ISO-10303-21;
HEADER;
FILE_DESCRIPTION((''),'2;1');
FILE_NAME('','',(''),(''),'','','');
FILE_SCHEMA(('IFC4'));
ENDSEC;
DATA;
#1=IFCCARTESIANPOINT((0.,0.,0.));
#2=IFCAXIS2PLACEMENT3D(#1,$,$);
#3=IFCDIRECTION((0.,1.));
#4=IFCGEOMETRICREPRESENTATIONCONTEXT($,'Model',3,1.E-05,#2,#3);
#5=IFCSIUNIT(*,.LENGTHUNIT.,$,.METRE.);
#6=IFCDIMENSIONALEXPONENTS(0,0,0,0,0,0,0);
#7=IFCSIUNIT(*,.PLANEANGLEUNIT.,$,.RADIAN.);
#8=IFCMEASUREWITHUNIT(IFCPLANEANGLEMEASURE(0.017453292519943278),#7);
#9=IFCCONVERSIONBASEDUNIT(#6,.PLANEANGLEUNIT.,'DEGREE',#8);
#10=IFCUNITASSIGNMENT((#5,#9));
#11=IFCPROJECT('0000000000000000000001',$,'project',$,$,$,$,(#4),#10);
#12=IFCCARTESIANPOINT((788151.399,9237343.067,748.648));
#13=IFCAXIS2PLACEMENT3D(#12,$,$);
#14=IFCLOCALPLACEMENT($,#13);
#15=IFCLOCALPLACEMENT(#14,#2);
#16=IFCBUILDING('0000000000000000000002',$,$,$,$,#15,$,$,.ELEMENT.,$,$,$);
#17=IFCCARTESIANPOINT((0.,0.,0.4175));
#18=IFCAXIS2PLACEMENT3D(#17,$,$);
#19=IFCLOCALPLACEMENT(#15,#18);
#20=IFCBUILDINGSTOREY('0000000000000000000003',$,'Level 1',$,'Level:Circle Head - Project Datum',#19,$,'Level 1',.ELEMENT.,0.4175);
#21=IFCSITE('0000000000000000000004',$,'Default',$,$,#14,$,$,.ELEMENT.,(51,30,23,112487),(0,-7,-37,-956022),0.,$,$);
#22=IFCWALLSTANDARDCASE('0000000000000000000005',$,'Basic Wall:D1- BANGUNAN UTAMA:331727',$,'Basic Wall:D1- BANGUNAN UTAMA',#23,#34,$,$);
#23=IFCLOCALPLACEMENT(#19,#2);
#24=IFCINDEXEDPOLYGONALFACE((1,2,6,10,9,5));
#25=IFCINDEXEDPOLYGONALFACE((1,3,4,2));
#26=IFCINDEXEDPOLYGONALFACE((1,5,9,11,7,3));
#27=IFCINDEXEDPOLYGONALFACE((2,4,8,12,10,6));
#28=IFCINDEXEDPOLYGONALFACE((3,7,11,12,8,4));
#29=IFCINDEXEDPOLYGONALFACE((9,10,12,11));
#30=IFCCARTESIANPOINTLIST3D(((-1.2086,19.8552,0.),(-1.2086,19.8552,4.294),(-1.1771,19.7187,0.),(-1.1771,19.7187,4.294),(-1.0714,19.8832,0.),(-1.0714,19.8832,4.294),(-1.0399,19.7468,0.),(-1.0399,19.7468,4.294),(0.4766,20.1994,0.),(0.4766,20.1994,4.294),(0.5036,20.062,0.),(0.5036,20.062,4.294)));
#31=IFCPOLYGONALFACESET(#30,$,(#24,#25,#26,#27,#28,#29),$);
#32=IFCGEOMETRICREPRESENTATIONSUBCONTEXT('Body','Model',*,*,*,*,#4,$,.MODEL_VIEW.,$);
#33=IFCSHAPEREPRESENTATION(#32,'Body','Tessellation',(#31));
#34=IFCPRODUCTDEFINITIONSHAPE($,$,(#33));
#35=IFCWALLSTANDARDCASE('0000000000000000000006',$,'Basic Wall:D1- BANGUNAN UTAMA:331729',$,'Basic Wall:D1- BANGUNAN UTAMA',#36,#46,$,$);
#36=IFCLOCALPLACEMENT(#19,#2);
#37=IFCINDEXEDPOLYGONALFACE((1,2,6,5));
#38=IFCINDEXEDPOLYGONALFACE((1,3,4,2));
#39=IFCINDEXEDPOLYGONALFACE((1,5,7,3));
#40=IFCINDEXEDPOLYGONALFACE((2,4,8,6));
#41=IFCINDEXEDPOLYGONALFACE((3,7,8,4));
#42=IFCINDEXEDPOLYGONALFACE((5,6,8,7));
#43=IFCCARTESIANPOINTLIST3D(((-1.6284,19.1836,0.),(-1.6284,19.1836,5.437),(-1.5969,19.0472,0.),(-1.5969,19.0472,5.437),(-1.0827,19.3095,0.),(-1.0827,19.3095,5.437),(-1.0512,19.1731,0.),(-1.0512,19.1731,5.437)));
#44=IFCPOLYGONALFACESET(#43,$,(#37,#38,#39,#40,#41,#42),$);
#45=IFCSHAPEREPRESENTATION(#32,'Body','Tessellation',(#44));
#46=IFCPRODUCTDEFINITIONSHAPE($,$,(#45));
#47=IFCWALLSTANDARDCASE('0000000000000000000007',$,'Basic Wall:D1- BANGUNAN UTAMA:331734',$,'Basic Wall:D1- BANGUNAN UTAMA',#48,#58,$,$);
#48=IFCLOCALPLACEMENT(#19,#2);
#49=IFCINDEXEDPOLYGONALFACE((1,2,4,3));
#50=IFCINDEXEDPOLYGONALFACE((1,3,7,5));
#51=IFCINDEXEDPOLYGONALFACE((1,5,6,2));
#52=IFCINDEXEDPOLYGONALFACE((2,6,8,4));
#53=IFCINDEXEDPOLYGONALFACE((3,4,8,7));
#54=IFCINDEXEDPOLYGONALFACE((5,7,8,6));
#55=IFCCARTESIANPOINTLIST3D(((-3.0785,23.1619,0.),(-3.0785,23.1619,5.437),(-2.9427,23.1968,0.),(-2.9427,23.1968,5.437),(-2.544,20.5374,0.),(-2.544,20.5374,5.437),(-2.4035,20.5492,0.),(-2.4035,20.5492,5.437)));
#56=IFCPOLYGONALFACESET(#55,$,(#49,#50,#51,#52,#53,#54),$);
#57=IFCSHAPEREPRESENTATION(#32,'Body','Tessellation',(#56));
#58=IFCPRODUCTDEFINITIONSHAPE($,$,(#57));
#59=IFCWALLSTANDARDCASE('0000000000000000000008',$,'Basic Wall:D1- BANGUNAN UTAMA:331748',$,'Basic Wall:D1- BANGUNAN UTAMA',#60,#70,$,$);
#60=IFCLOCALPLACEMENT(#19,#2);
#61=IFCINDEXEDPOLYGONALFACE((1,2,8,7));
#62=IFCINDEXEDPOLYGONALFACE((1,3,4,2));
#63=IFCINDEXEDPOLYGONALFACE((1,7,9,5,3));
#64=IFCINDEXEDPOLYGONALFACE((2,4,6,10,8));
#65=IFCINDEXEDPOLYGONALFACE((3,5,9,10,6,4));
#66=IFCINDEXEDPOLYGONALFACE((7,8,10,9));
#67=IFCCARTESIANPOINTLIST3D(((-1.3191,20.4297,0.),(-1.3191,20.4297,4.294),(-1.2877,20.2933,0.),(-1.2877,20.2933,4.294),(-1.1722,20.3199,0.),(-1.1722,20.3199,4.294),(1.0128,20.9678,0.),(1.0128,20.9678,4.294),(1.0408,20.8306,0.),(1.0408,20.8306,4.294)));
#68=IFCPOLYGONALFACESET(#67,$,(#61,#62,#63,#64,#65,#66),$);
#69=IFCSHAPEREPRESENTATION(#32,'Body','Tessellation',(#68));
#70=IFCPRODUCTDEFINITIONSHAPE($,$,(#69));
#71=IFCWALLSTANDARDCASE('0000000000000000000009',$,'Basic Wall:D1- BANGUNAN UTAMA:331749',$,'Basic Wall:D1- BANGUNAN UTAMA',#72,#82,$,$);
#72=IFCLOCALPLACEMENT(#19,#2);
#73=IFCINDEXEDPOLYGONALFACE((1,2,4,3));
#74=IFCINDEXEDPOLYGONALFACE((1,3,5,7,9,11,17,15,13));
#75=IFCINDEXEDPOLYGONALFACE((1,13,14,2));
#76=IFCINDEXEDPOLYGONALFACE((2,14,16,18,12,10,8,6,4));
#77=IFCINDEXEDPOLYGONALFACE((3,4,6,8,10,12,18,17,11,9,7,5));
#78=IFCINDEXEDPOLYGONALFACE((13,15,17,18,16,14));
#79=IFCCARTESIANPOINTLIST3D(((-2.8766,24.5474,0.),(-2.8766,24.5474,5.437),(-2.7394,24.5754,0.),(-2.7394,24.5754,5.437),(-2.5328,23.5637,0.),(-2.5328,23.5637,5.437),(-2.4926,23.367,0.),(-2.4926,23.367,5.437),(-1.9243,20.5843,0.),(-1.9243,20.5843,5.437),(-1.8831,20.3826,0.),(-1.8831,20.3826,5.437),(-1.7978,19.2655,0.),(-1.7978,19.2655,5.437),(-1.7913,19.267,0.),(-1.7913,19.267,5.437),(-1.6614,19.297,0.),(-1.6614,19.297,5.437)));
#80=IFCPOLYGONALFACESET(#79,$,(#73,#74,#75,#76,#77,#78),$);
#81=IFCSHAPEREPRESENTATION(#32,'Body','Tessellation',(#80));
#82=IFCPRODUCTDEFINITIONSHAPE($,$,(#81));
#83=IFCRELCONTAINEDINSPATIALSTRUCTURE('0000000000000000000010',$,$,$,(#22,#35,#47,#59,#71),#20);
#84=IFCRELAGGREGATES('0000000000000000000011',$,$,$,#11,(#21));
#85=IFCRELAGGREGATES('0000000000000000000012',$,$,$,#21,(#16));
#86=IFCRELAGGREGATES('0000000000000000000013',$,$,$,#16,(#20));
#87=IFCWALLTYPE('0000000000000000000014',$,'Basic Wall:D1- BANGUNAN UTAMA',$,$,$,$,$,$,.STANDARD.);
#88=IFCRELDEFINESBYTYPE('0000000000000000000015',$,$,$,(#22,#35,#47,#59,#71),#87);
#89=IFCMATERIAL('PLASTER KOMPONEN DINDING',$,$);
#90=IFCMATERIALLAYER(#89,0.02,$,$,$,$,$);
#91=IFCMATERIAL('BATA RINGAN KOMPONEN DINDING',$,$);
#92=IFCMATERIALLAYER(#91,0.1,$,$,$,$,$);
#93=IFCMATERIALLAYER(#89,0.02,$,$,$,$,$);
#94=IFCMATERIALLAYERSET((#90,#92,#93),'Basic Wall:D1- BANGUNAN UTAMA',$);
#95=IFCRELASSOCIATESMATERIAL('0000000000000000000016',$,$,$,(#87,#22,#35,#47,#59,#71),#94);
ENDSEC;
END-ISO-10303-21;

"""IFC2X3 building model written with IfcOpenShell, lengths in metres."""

from ifc_helpers import new_model, entity, si_unit, converted_unit, direction, frame, frame_2d, origin, place, context, subcontext, project, spatial, polyline, rectangle, outline, extrude, material, layer, layer_set, layer_usage, type_object, element, save


model = new_model("IFC2X3")

# Units and contexts
model_context = context("Model", 3, precision=1e-05, world=origin(), true_north=direction((0.0, 1.0)))
body_context = subcontext(model_context, "Body", "Model", "MODEL_VIEW")
ifc_project = project(units=[si_unit("LENGTHUNIT", "METRE"), converted_unit("PLANEANGLEUNIT", "DEGREE", entity("IfcPlaneAngleMeasure", 0.017453292519943278), si_unit("PLANEANGLEUNIT", "RADIAN"), dimensions=[0, 0, 0, 0, 0, 0, 0])], contexts=[model_context])

# Site, building, storey
site_placement = place(None, frame((788151.399, 9237343.067, 748.648)))
site = spatial("IfcSite", under=ifc_project, at=site_placement, Name="Default", CompositionType="ELEMENT", RefLatitude=(51, 30, 23, 112487), RefLongitude=(0, -7, -37, -956022), RefElevation=0.0)
building_placement = place(site_placement, origin())
building = spatial("IfcBuilding", under=site, at=building_placement, CompositionType="ELEMENT")
storey_placement = place(building_placement, frame((0.0, 0.0, 0.4175)))
storey = spatial("IfcBuildingStorey", under=building, at=storey_placement, Name="Level 1", ObjectType="Level:Circle Head - Project Datum", LongName="Level 1", CompositionType="ELEMENT", Elevation=0.4175)

# Walls
ifc_material_1 = material(Name="PLASTER KOMPONEN DINDING")
ifc_layer_1 = layer(ifc_material_1, 0.02)
ifc_material_2 = material(Name="BATA RINGAN KOMPONEN DINDING")
ifc_layer_2 = layer(ifc_material_2, 0.1)
ifc_layer_3 = layer(ifc_material_1, 0.02)
ifc_layer_set = layer_set([ifc_layer_1, ifc_layer_2, ifc_layer_3], Name="Basic Wall:D1- BANGUNAN UTAMA")
wall_type = type_object("IfcWallType", Name="Basic Wall:D1- BANGUNAN UTAMA", PredefinedType="STANDARD", material=ifc_layer_set)
ifc_layer_usage_1 = layer_usage(ifc_layer_set, "AXIS2", "POSITIVE", -0.07)
wall_1_placement = place(storey_placement, frame((0.4906, 20.1308, 0.0), z_axis=(0.0, 0.0, 1.0), x_axis=(-0.979774, -0.200109, 0.0)))
element("IfcWallStandardCase", 1, at=wall_1_placement, inside=storey, type_object=wall_type, material=ifc_layer_usage_1, Name="Basic Wall:D1- BANGUNAN UTAMA:331727", ObjectType="Basic Wall:D1- BANGUNAN UTAMA", context=body_context, shape_type="SweptSolid", body=[
    extrude(outline(polyline([(1.72, -0.07), (1.7164, 0.07), (1.5764, 0.07), (0.001, 0.07), (0.0, -0.07), (1.58, -0.07), (1.72, -0.07)])), origin(), (0.0, 0.0, 1.0), 4.294),
])
ifc_layer_usage_2 = layer_usage(ifc_layer_set, "AXIS2", "POSITIVE", -0.07)
wall_2_placement = place(storey_placement, frame((-1.067, 19.2413, 0.0), z_axis=(0.0, 0.0, 1.0), x_axis=(-0.974393, -0.224853, 0.0)))
element("IfcWallStandardCase", 2, at=wall_2_placement, inside=storey, type_object=wall_type, material=ifc_layer_usage_2, Name="Basic Wall:D1- BANGUNAN UTAMA:331729", ObjectType="Basic Wall:D1- BANGUNAN UTAMA", context=body_context, shape_type="SweptSolid", body=[
    extrude(rectangle(XDim=0.56, YDim=0.14, at=frame_2d((0.28, 0.0), x_axis=(-1.0, 0.0))), origin(), (0.0, 0.0, 1.0), 5.437),
])
ifc_layer_usage_3 = layer_usage(ifc_layer_set, "AXIS2", "POSITIVE", -0.07)
wall_3_placement = place(storey_placement, frame((-2.4721, 20.5352, 0.0), z_axis=(0.0, 0.0, 1.0), x_axis=(-0.19956, 0.979886, 0.0)))
element("IfcWallStandardCase", 3, at=wall_3_placement, inside=storey, type_object=wall_type, material=ifc_layer_usage_3, Name="Basic Wall:D1- BANGUNAN UTAMA:331734", ObjectType="Basic Wall:D1- BANGUNAN UTAMA", context=body_context, shape_type="SweptSolid", body=[
    extrude(outline(polyline([(2.702, -0.07), (2.6948, 0.07), (0.0164, 0.07), (0.0, -0.07), (2.702, -0.07)])), origin(), (0.0, 0.0, 1.0), 5.437),
])
ifc_layer_usage_4 = layer_usage(ifc_layer_set, "AXIS2", "POSITIVE", -0.07)
wall_4_placement = place(storey_placement, frame((-1.3034, 20.3615, 0.0), z_axis=(0.0, 0.0, 1.0), x_axis=(0.974393, 0.224853, 0.0)))
element("IfcWallStandardCase", 4, at=wall_4_placement, inside=storey, type_object=wall_type, material=ifc_layer_usage_4, Name="Basic Wall:D1- BANGUNAN UTAMA:331748", ObjectType="Basic Wall:D1- BANGUNAN UTAMA", context=body_context, shape_type="SweptSolid", body=[
    extrude(outline(polyline([(2.3896, -0.07), (2.3932, 0.07), (0.0, 0.07), (0.0, -0.07), (0.1185, -0.07), (2.3896, -0.07)])), origin(), (0.0, 0.0, 1.0), 4.294),
])
ifc_layer_usage_5 = layer_usage(ifc_layer_set, "AXIS2", "NEGATIVE", 0.07)
wall_5_placement = place(storey_placement, frame((-1.7292, 19.2795, 0.0), z_axis=(0.0, 0.0, 1.0), x_axis=(-0.200109, 0.979774, 0.0)))
element("IfcWallStandardCase", 5, at=wall_5_placement, inside=storey, type_object=wall_type, material=ifc_layer_usage_5, Name="Basic Wall:D1- BANGUNAN UTAMA:331749", ObjectType="Basic Wall:D1- BANGUNAN UTAMA", context=body_context, shape_type="SweptSolid", body=[
    extrude(outline(polyline([(5.391, -0.07), (5.391, 0.07), (0.0, 0.07), (0.0002, 0.0633), (0.0035, -0.07), (1.1116, -0.07), (1.3174, -0.07), (4.1576, -0.07), (4.3584, -0.07), (5.391, -0.07)])), origin(), (0.0, 0.0, 1.0), 5.437),
])

save(model, "model.ifc")
